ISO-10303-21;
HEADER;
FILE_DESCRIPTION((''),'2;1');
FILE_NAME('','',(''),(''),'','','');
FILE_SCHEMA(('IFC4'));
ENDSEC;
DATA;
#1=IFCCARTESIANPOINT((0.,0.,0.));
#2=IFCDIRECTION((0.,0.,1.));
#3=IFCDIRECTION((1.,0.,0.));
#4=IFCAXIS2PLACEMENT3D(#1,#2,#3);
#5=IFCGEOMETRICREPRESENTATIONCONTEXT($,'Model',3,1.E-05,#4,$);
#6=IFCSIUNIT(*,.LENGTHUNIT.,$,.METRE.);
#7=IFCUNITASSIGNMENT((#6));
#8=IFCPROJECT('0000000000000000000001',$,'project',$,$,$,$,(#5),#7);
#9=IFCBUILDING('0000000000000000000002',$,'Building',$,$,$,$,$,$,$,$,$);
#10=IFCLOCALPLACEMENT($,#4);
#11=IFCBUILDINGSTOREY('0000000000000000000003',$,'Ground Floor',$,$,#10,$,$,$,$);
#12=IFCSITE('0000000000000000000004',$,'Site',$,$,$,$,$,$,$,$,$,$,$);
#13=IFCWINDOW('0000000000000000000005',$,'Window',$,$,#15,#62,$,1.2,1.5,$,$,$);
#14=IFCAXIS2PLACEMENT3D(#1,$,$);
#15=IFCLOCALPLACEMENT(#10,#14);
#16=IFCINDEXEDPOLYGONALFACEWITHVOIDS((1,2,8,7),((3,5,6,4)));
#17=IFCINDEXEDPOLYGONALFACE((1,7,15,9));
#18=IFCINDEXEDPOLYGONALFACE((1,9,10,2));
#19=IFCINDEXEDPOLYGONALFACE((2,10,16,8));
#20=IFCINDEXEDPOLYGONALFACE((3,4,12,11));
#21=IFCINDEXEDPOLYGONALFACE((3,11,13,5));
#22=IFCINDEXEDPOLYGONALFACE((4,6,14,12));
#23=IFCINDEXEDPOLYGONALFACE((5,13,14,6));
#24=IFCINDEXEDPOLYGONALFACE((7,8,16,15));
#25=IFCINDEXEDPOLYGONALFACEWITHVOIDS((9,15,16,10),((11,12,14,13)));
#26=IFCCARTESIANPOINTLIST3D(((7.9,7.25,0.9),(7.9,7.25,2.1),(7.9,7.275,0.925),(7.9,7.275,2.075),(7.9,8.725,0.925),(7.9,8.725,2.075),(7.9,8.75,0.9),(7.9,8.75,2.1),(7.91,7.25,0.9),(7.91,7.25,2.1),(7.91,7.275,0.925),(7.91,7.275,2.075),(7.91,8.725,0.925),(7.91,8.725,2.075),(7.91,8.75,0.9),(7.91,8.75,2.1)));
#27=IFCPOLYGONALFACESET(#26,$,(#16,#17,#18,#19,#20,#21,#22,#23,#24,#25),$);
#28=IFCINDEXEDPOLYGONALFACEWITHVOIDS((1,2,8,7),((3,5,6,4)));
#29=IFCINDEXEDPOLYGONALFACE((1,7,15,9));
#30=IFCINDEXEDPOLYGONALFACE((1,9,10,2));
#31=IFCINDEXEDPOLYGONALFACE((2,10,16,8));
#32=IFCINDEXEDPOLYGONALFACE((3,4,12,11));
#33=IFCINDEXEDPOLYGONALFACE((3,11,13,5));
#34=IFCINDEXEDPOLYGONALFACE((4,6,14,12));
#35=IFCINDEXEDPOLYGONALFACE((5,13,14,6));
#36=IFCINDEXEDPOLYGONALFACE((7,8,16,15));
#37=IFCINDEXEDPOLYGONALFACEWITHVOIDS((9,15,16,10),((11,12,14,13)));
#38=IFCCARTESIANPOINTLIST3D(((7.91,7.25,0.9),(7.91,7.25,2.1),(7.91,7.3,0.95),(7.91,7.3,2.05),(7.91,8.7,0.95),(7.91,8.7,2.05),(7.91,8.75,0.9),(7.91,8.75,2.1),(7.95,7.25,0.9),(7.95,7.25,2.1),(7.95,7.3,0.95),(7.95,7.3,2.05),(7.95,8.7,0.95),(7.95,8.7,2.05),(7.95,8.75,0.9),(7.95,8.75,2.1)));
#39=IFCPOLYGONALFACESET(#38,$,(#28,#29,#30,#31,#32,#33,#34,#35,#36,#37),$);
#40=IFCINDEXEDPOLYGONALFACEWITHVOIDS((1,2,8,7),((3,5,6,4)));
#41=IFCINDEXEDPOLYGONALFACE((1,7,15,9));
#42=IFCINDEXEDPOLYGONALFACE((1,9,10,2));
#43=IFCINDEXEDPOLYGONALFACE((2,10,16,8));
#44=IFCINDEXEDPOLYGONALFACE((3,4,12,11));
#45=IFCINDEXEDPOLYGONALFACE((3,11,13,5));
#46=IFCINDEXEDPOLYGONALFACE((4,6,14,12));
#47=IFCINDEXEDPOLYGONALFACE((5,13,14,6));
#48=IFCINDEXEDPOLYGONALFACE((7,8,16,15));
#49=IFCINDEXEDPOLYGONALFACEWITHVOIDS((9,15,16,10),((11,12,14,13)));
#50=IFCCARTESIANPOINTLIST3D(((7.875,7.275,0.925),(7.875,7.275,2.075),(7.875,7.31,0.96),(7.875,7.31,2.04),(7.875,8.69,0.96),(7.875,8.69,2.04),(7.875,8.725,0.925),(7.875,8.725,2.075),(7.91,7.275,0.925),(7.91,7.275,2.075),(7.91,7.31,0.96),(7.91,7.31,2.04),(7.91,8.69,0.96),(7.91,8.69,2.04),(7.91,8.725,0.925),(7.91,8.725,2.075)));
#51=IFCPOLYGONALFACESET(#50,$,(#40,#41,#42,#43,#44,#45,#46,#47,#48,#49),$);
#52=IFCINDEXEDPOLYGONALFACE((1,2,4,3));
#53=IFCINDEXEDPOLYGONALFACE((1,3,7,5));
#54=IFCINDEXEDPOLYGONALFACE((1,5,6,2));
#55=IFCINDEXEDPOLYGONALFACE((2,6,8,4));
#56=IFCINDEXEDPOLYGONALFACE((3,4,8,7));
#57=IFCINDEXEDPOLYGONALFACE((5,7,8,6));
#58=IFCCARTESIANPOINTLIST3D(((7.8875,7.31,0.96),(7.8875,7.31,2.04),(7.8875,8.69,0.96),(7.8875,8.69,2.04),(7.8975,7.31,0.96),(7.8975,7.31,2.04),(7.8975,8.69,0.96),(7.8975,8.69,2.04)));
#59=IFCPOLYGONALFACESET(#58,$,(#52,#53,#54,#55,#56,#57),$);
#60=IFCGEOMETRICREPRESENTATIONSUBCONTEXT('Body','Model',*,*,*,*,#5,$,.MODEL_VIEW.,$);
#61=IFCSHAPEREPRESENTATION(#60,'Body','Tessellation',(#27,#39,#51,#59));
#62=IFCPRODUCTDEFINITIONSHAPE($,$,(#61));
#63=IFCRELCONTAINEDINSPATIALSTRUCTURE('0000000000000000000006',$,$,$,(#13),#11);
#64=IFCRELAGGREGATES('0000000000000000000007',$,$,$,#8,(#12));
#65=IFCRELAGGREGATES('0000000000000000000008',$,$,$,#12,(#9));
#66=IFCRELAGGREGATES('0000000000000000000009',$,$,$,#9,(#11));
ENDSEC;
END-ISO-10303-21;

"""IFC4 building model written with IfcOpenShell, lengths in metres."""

from ifc_helpers import new_model, si_unit, frame, origin_with_axes, place, context, subcontext, project, spatial, line, indexed_curve, outline, extrude, element, save


model = new_model("IFC4")

# Units and contexts
model_context = context("Model", 3, precision=1e-05, world=origin_with_axes())
body_context = subcontext(model_context, "Body", "Model", "MODEL_VIEW")
ifc_project = project(units=[si_unit("LENGTHUNIT", "METRE")], contexts=[model_context])

# Site, building, storey
site = spatial("IfcSite", under=ifc_project, Name="Site")
building = spatial("IfcBuilding", under=site, Name="Building")
storey_placement = place(None, origin_with_axes())
storey = spatial("IfcBuildingStorey", under=building, at=storey_placement, Name="Ground Floor")

# Window
for number, where, z_axis, x_axis, name in (
    (1, (8.0, 7.25, 0.9), (0.0, 0.0, 1.0), (0.0, 1.0, 0.0), "Window"),
):
    element("IfcWindow", number, at=place(storey_placement, frame(where, z_axis=z_axis, x_axis=x_axis)), inside=storey, Name=name, OverallHeight=1.2, OverallWidth=1.5, context=body_context, shape_type="SweptSolid", body=[
        extrude(outline(indexed_curve([(0.0, 0.0), (1.5, 0.0), (1.5, 1.2), (0.0, 1.2)], segments=[line(1, 2, 3, 4, 1)]), holes=[indexed_curve([(0.025, 0.025), (1.475, 0.025), (1.475, 1.175), (0.025, 1.175)], segments=[line(1, 2, 3, 4, 1)])]), frame((0.0, 0.09, 0.0), z_axis=(0.0, -1.0, 0.0), x_axis=(1.0, 0.0, 0.0)), (0.0, 0.0, -1.0), 0.01),
        extrude(outline(indexed_curve([(0.0, 0.0), (1.5, 0.0), (1.5, 1.2), (0.0, 1.2)], segments=[line(1, 2, 3, 4, 1)]), holes=[indexed_curve([(0.05, 0.05), (1.45, 0.05), (1.45, 1.15), (0.05, 1.15)], segments=[line(1, 2, 3, 4, 1)])]), frame((0.0, 0.05, 0.0), z_axis=(0.0, -1.0, 0.0), x_axis=(1.0, 0.0, 0.0)), (0.0, 0.0, -1.0), 0.04),
        extrude(outline(indexed_curve([(0.0, 0.0), (1.45, 0.0), (1.45, 1.15), (0.0, 1.15)], segments=[line(1, 2, 3, 4, 1)]), holes=[indexed_curve([(0.035, 0.035), (1.415, 0.035), (1.415, 1.115), (0.035, 1.115)], segments=[line(1, 2, 3, 4, 1)])]), frame((0.025, 0.09, 0.025), z_axis=(0.0, -1.0, 0.0), x_axis=(1.0, 0.0, 0.0)), (0.0, 0.0, -1.0), 0.035),
        extrude(outline(indexed_curve([(0.035, 0.035), (1.415, 0.035), (1.415, 1.115), (0.035, 1.115)], segments=[line(1, 2, 3, 4, 1)])), frame((0.025, 0.1025, 0.025), z_axis=(0.0, -1.0, 0.0), x_axis=(1.0, 0.0, 0.0)), (0.0, 0.0, -1.0), 0.01),
    ])

save(model, "model.ifc")
